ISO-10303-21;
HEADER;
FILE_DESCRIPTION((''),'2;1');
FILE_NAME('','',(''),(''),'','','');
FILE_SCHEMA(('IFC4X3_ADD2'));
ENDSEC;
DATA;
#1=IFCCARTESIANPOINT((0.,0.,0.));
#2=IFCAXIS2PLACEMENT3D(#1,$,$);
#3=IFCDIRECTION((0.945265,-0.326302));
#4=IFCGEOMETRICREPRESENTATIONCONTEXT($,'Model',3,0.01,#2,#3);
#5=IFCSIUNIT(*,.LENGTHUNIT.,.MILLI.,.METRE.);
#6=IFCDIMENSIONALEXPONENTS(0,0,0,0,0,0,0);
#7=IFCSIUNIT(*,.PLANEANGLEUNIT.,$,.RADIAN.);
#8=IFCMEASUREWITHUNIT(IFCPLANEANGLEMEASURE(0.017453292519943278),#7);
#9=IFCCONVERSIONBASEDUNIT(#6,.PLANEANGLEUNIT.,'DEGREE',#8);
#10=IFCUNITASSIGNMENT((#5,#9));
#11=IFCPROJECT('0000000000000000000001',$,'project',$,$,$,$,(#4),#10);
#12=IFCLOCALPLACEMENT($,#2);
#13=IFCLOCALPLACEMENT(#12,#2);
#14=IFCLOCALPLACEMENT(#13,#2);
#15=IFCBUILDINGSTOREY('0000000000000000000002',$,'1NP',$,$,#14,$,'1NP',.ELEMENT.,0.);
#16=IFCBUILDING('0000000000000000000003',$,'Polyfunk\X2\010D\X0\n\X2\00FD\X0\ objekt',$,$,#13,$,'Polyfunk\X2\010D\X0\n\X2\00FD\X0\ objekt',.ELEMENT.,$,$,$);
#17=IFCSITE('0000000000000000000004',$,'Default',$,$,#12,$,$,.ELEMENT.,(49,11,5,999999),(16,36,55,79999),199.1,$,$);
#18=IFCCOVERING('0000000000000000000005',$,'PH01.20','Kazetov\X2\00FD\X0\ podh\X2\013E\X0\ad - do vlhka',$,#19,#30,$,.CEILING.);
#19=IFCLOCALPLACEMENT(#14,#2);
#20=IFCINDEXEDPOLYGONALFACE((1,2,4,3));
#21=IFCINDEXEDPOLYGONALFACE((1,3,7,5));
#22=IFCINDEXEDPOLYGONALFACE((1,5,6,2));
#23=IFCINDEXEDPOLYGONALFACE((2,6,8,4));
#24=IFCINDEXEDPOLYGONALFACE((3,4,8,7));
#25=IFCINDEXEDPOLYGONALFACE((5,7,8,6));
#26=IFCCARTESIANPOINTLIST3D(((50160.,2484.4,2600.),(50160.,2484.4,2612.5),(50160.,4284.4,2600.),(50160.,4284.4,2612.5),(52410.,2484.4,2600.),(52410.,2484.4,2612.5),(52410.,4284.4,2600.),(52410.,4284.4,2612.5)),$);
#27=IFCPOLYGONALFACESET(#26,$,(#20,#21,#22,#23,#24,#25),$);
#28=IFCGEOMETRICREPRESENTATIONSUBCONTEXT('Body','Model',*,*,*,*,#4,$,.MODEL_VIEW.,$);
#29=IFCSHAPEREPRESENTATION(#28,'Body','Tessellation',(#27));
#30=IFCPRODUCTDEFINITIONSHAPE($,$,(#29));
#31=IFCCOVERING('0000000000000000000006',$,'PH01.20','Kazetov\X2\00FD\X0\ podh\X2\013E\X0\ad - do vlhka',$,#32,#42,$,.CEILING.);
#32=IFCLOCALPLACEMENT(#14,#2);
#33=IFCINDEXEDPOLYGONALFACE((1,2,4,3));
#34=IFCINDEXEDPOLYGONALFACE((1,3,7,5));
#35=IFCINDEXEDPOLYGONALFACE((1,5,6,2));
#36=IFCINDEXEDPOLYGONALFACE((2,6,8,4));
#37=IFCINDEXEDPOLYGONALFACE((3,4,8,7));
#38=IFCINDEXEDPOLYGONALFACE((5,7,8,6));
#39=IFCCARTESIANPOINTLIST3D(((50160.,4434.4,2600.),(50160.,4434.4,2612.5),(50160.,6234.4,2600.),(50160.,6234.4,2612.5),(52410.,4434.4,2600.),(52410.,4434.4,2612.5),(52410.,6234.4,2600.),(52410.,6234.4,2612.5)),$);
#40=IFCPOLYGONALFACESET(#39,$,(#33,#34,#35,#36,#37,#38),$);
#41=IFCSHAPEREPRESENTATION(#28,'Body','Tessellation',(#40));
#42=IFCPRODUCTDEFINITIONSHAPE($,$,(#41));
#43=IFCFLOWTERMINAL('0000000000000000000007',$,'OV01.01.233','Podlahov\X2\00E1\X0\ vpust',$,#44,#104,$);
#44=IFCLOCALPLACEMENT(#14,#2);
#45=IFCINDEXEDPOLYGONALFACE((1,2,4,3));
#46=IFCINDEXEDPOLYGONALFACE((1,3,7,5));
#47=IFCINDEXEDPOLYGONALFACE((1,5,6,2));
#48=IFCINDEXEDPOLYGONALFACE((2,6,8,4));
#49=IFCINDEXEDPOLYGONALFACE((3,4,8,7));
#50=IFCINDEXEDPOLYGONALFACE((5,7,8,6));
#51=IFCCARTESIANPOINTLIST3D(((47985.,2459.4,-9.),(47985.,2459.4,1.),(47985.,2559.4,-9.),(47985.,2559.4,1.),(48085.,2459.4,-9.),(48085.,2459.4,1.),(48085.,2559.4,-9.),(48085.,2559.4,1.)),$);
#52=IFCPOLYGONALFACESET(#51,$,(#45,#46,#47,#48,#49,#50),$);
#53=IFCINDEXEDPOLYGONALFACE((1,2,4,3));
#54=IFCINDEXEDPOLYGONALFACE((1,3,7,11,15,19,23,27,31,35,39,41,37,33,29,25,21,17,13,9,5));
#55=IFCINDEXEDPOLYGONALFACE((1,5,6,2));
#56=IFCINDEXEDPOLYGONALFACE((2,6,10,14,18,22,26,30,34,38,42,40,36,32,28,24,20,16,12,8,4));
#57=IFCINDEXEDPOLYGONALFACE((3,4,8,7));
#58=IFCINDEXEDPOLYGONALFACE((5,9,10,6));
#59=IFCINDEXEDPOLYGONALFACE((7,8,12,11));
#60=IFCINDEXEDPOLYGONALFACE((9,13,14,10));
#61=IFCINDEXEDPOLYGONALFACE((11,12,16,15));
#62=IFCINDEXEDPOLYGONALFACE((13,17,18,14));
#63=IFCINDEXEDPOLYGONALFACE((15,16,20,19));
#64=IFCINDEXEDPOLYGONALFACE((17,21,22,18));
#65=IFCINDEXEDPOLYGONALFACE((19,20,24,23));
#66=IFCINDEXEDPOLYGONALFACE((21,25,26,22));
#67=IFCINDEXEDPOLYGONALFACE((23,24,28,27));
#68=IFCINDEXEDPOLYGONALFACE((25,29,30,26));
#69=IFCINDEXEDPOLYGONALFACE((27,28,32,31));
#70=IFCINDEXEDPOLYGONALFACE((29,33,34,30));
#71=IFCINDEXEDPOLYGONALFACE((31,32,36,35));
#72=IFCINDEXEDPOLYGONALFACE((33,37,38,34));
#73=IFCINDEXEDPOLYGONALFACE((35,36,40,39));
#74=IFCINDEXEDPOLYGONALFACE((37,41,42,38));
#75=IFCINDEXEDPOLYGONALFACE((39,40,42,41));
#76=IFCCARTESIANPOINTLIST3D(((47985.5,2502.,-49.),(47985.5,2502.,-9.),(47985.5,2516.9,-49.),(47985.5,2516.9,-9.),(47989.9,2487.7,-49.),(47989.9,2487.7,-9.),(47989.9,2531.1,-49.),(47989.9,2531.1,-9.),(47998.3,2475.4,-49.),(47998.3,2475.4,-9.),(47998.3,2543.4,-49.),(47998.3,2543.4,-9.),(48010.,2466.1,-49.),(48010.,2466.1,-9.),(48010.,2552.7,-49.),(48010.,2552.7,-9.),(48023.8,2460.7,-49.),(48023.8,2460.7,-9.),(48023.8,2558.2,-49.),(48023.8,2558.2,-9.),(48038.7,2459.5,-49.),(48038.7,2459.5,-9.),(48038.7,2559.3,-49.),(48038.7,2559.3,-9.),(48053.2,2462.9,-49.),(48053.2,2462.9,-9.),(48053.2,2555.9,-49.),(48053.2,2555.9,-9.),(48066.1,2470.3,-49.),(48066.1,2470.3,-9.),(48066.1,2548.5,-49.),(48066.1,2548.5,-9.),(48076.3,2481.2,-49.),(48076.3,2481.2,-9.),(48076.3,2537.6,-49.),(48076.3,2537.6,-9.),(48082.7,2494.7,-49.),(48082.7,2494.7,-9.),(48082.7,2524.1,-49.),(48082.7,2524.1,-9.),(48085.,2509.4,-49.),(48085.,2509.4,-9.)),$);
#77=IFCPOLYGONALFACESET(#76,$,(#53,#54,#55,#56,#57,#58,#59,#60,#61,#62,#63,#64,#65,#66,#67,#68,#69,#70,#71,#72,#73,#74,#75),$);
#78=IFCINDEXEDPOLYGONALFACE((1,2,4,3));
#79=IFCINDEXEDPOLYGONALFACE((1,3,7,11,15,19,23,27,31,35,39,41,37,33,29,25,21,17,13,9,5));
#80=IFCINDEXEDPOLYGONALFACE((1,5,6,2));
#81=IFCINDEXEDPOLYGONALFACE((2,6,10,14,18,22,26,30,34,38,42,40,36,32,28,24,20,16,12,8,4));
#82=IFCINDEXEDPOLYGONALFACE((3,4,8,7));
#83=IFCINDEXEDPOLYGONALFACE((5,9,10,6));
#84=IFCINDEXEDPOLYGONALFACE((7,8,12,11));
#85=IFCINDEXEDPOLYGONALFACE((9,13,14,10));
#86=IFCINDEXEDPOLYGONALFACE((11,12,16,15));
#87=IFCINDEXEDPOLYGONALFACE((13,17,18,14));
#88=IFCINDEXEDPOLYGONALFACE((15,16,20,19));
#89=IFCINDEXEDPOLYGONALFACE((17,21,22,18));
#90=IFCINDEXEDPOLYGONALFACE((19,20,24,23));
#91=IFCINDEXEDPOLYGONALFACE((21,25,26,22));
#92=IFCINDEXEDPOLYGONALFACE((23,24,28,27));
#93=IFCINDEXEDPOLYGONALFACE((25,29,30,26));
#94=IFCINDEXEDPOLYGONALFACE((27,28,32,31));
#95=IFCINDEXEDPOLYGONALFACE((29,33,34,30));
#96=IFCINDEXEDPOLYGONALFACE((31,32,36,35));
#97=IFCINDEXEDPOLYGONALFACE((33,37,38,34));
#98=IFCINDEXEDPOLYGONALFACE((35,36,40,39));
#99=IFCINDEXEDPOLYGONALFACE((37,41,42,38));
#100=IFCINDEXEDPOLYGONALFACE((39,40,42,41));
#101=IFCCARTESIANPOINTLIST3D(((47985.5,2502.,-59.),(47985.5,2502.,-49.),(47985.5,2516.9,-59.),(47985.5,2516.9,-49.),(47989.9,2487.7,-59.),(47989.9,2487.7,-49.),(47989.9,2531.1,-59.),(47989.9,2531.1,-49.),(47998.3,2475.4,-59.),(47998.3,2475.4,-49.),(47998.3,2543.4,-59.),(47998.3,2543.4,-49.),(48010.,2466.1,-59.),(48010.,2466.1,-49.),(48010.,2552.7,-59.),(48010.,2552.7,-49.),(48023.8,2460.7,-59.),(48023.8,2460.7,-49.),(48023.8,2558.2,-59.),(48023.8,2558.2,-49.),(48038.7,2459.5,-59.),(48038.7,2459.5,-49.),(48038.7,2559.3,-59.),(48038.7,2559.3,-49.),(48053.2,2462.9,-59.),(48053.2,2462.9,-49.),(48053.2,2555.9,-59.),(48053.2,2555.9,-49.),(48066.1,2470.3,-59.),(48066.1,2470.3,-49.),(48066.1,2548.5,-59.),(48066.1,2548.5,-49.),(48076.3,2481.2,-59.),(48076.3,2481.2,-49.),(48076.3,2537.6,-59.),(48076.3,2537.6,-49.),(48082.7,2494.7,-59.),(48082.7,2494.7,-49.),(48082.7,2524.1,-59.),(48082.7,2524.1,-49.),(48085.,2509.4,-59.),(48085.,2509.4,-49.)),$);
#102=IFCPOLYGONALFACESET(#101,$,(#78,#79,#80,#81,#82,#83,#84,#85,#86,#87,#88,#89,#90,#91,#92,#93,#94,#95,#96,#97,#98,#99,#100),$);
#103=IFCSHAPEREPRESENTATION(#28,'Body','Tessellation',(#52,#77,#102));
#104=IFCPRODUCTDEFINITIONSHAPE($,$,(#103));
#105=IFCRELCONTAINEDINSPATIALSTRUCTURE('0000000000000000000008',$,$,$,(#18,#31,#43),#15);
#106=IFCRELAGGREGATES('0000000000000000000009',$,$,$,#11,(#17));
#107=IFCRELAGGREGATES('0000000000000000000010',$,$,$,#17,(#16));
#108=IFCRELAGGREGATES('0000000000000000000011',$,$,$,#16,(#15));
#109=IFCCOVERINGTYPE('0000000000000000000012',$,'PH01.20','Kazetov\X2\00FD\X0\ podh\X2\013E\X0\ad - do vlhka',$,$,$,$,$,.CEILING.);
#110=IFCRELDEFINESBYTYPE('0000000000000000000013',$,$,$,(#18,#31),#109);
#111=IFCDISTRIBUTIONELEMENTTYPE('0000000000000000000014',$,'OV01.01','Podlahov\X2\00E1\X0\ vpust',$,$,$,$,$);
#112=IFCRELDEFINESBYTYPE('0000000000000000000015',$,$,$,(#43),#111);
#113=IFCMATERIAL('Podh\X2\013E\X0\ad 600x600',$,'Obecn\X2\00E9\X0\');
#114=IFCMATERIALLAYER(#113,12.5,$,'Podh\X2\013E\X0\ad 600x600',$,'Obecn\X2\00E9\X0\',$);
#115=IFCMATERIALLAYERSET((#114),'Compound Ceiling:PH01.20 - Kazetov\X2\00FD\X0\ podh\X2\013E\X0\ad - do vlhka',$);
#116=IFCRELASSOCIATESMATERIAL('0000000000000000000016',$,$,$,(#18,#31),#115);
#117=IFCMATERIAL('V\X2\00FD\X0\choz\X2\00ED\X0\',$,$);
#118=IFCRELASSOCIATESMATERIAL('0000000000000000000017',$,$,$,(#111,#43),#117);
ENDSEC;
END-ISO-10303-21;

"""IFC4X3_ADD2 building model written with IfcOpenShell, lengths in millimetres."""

from ifc_helpers import new_model, entity, si_unit, converted_unit, direction, frame, frame_2d, origin, place, context, subcontext, project, spatial, rectangle, circle, extrude, source, transform, mapped, material, layer, layer_set, layer_usage, type_object, type_shapes, element, save


model = new_model("IFC4X3_ADD2")

# Units and contexts
model_context = context("Model", 3, precision=0.01, world=origin(), true_north=direction((0.945265, -0.326302)))
body_context = subcontext(model_context, "Body", "Model", "MODEL_VIEW")
ifc_project = project(units=[si_unit("LENGTHUNIT", "METRE", prefix="MILLI"), converted_unit("PLANEANGLEUNIT", "DEGREE", entity("IfcPlaneAngleMeasure", 0.017453292519943278), si_unit("PLANEANGLEUNIT", "RADIAN"), dimensions=[0, 0, 0, 0, 0, 0, 0])], contexts=[model_context])

# Site, building, storey
site_placement = place(None, origin())
site = spatial("IfcSite", under=ifc_project, at=site_placement, Name="Default", CompositionType="ELEMENT", RefLatitude=(49, 11, 5, 999999), RefLongitude=(16, 36, 55, 79999), RefElevation=199.1)
building_placement = place(site_placement, origin())
building = spatial("IfcBuilding", under=site, at=building_placement, Name="Polyfunkčný objekt", LongName="Polyfunkčný objekt", CompositionType="ELEMENT")
storey_placement = place(building_placement, origin())
storey = spatial("IfcBuildingStorey", under=building, at=storey_placement, Name="1NP", LongName="1NP", CompositionType="ELEMENT", Elevation=0.0)

# Coverings
ifc_material_1 = material(Name="Podhľad 600x600", Category="Obecné")
ifc_layer_1 = layer(ifc_material_1, 12.5, Name="Podhľad 600x600", Category="Obecné")
ifc_layer_set_1 = layer_set([ifc_layer_1], Name="Compound Ceiling:PH01.20 - Kazetový podhľad - do vlhka")
covering_type_1 = type_object("IfcCoveringType", Name="PH01.20", Description="Kazetový podhľad - do vlhka", PredefinedType="CEILING")
ifc_layer_usage_1 = layer_usage(ifc_layer_set_1, "AXIS3", "NEGATIVE", 0.0)
covering_1_placement = place(storey_placement, frame((50160.0, 2484.4, 2600.0)))
element("IfcCovering", 1, at=covering_1_placement, inside=storey, type_object=covering_type_1, material=ifc_layer_usage_1, Name="PH01.20", Description="Kazetový podhľad - do vlhka", PredefinedType="CEILING", context=body_context, shape_type="SweptSolid", body=[
    extrude(rectangle(XDim=2250.0, YDim=1800.0, at=frame_2d((0.0, 0.0), x_axis=(1.0, 0.0))), frame((1125.0, 900.0, 0.0), z_axis=(0.0, 0.0, 1.0), x_axis=(-1.0, 0.0, 0.0)), (0.0, 0.0, 1.0), 12.5),
])
ifc_layer_usage_2 = layer_usage(ifc_layer_set_1, "AXIS3", "NEGATIVE", 0.0)
covering_2_placement = place(storey_placement, frame((50160.0, 4434.4, 2600.0)))
element("IfcCovering", 2, at=covering_2_placement, inside=storey, type_object=covering_type_1, material=ifc_layer_usage_2, Name="PH01.20", Description="Kazetový podhľad - do vlhka", PredefinedType="CEILING", context=body_context, shape_type="SweptSolid", body=[
    extrude(rectangle(XDim=1800.0, YDim=2250.0, at=frame_2d((0.0, 0.0), x_axis=(1.0, 0.0))), frame((1125.0, 900.0, 0.0), z_axis=(0.0, 0.0, 1.0), x_axis=(0.0, -1.0, 0.0)), (0.0, 0.0, 1.0), 12.5),
])

# Flow terminal
ifc_material_2 = material(Name="Výchozí")
distribution_element_type = type_object("IfcDistributionElementType", Name="OV01.01", Description="Podlahová vpust", material=ifc_material_2)
shared_shape_1 = source(origin(), body_context, "Body", "SweptSolid", [
    extrude(rectangle(XDim=100.0, YDim=100.0, at=frame_2d((0.0, 0.0), x_axis=(1.0, 0.0))), frame((0.0, 0.0, -10.0), z_axis=(0.0, 0.0, 1.0), x_axis=(-1.0, 0.0, 0.0)), (0.0, 0.0, 1.0), 10.0),
    extrude(circle(Radius=50.0, at=frame_2d((0.0, 0.0), x_axis=(1.0, 0.0))), frame((0.0, 0.0, -50.0)), (0.0, 0.0, 1.0), 40.0),
    extrude(circle(Radius=50.0, at=frame_2d((0.0, 0.0), x_axis=(1.0, 0.0))), frame((0.0, 0.0, -60.0)), (0.0, 0.0, 1.0), 10.0),
])
type_shapes(distribution_element_type, [shared_shape_1])
flow_terminal_placement = place(storey_placement, frame((48035.0, 2509.4, 1.0)))
element("IfcFlowTerminal", 3, at=flow_terminal_placement, inside=storey, type_object=distribution_element_type, material=ifc_material_2, Name="OV01.01.233", Description="Podlahová vpust", context=body_context, shape_type="MappedRepresentation", body=[
    mapped(shared_shape_1, transform((0.0, 0.0, 0.0), scale=1.0)),
])

save(model, "model.ifc")
